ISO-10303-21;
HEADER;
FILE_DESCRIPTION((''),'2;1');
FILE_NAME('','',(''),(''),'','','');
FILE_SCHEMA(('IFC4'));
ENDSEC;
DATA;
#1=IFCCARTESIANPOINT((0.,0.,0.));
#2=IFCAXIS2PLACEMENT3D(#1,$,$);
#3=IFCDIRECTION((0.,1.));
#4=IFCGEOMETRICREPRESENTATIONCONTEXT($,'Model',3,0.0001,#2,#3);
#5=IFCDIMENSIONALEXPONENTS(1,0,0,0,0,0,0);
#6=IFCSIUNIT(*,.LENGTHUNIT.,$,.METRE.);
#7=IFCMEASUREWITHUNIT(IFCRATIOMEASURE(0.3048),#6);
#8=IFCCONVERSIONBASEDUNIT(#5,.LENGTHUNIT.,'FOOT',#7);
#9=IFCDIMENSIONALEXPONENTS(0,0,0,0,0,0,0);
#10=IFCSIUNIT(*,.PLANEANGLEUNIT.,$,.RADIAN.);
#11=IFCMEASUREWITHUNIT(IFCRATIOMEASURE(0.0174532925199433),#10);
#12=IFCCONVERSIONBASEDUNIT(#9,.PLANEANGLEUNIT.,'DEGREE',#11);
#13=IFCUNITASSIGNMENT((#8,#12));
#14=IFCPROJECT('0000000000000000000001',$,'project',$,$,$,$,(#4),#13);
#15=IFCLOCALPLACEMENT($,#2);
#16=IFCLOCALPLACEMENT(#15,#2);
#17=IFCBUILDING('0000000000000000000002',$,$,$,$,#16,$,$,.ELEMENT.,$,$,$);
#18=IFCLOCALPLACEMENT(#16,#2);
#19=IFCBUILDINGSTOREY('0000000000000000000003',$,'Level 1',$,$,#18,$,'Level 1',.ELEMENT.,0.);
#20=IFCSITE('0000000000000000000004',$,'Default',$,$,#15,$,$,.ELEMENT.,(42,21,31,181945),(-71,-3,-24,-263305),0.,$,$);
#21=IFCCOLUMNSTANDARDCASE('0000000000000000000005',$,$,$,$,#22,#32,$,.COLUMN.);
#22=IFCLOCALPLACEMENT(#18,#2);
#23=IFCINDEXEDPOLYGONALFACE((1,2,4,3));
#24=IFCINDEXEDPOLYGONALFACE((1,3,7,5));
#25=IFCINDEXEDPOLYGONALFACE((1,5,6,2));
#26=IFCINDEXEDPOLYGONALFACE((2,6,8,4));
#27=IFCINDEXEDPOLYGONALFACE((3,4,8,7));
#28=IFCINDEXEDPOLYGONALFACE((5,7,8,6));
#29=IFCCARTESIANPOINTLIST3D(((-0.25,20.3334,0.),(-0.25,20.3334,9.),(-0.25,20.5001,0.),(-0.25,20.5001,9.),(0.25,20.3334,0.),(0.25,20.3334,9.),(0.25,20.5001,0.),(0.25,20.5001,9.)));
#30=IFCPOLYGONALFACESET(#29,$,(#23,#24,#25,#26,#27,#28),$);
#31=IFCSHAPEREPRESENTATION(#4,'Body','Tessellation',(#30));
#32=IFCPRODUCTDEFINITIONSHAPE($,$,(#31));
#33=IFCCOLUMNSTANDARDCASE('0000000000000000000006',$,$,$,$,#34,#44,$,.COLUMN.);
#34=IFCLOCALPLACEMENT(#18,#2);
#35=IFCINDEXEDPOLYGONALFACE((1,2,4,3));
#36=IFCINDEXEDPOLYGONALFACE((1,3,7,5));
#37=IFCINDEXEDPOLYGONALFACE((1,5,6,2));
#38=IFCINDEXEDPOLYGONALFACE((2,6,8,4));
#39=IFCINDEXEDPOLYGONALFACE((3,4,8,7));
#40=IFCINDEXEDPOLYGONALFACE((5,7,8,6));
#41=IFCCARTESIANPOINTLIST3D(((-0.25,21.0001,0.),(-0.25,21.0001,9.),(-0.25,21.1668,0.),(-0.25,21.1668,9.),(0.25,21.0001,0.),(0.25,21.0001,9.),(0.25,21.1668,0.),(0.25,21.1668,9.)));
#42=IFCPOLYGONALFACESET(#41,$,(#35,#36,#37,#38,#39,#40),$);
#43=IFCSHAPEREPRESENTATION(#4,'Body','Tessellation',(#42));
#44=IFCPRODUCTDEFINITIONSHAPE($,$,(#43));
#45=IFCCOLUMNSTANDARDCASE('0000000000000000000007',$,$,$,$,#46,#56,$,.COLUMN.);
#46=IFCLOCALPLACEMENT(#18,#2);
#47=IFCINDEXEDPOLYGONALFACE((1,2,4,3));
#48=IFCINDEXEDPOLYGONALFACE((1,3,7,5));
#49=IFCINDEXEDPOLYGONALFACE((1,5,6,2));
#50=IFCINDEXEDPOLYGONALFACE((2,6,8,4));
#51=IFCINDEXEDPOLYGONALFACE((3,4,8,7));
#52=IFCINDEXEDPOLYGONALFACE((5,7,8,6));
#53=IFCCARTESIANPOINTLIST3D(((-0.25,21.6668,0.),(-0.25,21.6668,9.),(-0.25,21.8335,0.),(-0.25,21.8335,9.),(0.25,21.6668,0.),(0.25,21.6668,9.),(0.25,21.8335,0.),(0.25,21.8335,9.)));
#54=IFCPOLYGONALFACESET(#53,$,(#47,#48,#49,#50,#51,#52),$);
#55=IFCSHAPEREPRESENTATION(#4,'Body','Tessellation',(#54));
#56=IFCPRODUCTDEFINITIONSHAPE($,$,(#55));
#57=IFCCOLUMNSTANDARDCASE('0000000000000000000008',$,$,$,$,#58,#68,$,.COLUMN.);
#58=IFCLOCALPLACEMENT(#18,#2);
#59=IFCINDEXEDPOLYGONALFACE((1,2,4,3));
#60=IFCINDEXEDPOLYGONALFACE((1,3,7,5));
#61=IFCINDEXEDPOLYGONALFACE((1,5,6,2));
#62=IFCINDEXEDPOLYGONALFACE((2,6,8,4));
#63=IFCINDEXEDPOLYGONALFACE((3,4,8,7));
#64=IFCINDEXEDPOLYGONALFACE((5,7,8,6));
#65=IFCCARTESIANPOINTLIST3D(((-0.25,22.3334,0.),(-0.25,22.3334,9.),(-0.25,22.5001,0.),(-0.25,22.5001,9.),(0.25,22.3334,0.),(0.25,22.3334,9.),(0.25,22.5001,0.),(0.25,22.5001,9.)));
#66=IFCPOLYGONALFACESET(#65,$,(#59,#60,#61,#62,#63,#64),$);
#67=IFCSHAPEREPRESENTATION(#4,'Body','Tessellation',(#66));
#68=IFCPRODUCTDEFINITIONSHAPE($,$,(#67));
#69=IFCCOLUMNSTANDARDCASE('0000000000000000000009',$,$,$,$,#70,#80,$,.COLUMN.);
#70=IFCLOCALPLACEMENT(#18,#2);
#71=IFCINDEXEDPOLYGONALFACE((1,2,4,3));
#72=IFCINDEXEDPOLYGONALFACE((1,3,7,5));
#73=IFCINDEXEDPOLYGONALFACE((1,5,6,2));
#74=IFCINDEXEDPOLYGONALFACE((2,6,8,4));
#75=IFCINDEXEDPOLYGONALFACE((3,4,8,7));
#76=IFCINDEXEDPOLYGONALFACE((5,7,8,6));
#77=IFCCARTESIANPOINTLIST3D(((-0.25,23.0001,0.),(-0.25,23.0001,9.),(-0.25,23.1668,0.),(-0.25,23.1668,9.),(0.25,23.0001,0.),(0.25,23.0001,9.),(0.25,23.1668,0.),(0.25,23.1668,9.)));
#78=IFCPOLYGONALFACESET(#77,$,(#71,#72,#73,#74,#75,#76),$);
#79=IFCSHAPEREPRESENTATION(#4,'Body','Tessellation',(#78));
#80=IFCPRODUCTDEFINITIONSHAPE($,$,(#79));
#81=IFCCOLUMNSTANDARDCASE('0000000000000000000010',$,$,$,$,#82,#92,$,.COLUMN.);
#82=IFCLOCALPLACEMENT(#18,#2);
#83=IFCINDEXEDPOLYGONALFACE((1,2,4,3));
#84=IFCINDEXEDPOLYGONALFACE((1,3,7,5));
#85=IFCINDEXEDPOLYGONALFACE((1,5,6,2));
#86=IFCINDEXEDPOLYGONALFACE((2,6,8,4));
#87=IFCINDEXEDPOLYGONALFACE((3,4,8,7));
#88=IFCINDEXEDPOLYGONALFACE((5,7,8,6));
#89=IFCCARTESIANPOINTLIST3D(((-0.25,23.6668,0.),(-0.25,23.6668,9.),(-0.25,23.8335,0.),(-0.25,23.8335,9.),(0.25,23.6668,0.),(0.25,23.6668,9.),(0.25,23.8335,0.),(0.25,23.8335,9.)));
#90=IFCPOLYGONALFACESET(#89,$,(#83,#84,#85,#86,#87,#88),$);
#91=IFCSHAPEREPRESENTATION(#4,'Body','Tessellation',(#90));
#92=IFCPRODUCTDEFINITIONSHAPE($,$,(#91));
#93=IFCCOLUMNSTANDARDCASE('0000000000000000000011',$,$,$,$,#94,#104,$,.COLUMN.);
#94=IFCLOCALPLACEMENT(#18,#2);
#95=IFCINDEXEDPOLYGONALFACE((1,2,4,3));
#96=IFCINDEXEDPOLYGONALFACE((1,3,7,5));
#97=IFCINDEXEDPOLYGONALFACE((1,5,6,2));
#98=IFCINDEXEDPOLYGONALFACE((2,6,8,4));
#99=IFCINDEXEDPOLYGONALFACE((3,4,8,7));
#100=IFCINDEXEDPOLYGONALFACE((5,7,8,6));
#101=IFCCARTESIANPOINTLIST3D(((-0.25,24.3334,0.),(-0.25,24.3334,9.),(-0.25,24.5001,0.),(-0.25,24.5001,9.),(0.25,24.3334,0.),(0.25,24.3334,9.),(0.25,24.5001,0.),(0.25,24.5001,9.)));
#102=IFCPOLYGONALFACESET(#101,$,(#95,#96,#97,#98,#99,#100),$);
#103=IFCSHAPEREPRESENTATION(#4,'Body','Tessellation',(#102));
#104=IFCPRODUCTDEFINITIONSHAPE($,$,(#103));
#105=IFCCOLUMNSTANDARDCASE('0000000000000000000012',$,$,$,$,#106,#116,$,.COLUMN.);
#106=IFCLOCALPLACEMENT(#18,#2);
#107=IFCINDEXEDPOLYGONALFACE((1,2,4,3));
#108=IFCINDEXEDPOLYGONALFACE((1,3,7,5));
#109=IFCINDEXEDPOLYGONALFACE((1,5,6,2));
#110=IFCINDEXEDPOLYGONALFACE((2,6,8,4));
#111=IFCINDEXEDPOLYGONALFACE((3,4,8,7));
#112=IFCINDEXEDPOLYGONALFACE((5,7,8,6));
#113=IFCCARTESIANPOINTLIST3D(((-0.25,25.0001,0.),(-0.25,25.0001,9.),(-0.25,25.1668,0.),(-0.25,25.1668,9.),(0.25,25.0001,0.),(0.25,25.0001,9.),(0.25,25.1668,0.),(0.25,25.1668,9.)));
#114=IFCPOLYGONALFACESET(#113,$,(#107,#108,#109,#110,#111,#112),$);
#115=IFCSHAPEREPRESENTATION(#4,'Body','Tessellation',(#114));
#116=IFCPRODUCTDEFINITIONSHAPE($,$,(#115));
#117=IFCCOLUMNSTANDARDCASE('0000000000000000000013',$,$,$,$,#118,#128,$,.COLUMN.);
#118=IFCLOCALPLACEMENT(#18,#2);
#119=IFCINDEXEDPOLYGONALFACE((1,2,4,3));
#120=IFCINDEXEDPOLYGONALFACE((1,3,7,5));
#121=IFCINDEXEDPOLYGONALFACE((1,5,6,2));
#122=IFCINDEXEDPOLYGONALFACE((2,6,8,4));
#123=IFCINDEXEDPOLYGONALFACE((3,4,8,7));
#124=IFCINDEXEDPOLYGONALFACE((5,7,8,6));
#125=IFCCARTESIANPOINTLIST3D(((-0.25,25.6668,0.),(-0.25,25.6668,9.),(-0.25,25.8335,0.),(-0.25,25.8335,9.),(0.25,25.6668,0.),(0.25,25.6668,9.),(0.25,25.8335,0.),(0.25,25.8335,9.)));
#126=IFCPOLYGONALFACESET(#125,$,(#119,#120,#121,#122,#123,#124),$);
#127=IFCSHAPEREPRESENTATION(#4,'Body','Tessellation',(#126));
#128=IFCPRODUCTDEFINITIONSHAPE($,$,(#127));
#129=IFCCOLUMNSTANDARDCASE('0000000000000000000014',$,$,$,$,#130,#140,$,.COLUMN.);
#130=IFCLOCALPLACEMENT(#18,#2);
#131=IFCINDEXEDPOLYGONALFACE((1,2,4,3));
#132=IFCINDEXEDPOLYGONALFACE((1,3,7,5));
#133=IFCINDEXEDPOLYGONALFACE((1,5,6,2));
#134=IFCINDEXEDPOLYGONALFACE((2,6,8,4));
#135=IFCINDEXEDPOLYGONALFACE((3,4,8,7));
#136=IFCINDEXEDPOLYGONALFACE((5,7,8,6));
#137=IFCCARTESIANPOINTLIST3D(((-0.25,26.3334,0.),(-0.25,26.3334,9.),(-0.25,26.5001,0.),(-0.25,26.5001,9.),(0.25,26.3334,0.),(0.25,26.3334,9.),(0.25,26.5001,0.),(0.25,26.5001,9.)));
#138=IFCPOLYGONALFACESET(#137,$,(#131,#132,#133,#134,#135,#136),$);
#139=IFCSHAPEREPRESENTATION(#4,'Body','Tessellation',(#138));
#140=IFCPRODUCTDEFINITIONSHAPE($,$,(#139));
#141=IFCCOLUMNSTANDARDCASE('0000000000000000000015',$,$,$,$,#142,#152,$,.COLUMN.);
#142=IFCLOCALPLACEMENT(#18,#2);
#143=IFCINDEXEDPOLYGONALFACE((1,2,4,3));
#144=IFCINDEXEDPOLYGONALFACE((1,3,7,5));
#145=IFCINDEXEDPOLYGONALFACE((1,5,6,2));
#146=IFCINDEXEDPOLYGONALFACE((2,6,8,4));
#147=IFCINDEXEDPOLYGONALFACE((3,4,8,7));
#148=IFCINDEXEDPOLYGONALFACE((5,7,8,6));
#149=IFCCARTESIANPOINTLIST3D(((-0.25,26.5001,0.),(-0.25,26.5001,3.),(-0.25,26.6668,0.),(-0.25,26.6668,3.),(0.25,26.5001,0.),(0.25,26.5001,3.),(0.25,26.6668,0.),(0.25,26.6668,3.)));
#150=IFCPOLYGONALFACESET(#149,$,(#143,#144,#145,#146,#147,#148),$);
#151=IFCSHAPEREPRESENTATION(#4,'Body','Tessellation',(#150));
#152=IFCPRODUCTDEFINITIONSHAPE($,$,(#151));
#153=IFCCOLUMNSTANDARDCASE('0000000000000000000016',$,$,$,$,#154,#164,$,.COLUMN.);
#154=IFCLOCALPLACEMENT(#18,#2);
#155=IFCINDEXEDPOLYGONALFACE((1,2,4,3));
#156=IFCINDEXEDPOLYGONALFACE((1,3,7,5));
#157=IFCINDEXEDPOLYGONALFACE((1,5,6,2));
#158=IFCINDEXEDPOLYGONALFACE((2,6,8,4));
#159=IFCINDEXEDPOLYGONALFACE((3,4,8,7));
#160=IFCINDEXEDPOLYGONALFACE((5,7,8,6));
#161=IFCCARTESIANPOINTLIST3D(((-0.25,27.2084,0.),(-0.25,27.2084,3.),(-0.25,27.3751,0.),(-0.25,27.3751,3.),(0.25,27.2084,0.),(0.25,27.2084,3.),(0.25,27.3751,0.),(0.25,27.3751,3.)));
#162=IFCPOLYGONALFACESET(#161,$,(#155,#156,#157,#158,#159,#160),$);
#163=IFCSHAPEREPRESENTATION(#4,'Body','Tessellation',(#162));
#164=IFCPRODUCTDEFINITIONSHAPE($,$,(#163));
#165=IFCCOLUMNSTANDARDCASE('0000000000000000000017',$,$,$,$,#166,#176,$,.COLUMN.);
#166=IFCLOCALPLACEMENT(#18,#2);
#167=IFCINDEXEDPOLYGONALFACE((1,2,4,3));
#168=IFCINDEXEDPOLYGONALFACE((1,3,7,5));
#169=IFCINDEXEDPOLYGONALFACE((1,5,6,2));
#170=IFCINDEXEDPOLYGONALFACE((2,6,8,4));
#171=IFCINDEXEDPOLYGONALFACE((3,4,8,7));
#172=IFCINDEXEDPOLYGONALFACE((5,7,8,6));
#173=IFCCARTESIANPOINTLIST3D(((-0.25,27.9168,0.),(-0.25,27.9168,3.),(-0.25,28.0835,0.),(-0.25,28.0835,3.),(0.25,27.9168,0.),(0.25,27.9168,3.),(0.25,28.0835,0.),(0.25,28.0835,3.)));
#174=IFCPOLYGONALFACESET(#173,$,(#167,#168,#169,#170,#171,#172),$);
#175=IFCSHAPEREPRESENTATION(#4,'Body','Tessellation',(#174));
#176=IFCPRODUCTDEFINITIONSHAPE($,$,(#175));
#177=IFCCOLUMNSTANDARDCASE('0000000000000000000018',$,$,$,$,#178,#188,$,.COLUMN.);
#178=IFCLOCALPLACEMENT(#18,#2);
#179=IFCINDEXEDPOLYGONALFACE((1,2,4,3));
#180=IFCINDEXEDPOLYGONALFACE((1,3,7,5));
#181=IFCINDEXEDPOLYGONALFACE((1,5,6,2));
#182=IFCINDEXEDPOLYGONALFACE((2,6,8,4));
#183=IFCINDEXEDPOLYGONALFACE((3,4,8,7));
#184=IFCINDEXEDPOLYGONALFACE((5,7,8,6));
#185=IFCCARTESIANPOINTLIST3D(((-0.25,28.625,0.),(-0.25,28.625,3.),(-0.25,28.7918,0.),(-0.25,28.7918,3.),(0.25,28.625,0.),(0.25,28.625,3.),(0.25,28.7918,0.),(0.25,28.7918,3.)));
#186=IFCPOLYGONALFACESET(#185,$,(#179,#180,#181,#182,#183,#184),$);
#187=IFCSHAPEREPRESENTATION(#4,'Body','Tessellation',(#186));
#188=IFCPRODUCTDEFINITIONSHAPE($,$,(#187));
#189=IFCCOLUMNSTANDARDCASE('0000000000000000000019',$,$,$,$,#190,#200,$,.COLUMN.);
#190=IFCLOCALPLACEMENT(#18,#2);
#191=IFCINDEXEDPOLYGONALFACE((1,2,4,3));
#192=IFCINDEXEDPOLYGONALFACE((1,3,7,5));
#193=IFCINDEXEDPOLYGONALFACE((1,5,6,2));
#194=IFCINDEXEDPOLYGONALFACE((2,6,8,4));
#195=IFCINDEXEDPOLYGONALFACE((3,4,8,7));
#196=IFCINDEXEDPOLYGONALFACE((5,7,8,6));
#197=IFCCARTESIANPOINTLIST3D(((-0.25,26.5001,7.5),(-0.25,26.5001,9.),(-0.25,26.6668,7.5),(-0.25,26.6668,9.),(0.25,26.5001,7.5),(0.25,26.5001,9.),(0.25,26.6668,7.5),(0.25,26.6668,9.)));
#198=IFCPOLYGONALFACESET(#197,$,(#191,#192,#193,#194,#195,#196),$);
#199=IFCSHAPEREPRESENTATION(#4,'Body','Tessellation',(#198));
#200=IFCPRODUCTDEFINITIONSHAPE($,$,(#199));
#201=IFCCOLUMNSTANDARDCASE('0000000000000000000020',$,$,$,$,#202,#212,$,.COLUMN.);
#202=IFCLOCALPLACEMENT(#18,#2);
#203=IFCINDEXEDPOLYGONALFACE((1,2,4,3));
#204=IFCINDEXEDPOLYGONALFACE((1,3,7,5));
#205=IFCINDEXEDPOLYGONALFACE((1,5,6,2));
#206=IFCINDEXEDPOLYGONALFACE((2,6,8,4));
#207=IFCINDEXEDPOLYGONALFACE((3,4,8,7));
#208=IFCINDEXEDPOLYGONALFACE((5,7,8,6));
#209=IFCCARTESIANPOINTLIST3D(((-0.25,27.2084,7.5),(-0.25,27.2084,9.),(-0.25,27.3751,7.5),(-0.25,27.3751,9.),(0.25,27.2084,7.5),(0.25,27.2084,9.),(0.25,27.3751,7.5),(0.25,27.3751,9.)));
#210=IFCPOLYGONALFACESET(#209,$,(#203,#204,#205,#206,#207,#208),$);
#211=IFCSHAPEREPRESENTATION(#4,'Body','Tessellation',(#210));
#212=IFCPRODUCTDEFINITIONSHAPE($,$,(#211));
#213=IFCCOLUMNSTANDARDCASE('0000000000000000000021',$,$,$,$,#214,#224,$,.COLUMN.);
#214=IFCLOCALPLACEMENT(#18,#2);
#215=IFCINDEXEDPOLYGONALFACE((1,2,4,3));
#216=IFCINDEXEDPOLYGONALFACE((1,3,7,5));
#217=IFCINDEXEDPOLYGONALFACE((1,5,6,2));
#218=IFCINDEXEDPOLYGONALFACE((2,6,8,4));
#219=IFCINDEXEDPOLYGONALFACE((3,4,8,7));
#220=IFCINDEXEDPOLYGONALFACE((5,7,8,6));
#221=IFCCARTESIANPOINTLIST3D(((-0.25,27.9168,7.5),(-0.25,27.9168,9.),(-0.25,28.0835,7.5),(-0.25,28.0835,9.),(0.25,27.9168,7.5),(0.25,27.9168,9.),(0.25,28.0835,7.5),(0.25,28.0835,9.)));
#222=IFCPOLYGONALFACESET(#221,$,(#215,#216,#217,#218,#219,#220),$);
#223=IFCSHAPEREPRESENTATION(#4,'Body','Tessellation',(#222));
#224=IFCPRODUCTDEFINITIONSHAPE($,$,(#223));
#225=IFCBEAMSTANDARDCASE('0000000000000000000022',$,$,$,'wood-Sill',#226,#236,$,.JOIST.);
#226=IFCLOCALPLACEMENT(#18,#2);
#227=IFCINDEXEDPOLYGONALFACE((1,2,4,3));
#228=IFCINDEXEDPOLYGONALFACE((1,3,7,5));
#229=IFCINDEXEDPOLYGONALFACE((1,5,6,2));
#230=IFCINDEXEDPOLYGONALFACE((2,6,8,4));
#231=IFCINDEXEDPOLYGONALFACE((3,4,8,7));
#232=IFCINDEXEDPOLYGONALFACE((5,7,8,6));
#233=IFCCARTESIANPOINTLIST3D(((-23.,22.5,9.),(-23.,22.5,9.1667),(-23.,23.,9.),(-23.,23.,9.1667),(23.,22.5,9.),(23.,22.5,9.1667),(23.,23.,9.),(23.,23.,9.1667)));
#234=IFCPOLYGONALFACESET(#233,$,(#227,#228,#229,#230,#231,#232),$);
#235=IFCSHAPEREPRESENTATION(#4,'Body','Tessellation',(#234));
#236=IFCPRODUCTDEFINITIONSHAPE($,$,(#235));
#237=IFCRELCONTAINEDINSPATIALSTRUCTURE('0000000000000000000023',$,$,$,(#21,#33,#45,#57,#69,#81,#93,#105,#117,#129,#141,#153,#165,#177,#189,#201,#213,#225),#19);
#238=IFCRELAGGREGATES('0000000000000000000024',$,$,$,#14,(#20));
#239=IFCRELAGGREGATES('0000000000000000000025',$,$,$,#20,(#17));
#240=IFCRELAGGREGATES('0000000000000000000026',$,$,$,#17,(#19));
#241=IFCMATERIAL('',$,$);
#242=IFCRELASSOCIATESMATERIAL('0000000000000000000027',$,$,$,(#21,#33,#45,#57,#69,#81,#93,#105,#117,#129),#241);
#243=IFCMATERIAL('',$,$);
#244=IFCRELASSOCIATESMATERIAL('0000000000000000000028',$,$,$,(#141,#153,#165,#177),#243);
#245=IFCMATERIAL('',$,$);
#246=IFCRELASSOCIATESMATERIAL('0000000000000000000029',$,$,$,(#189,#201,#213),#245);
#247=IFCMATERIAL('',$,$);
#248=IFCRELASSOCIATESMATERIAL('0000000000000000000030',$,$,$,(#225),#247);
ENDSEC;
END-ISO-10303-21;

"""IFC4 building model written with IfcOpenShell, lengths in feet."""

from ifc_helpers import new_model, entity, si_unit, converted_unit, direction, frame, origin, place, context, project, spatial, rectangle, extrude, material, element, save


model = new_model("IFC4")

# Units and contexts
model_context = context("Model", 3, precision=0.0001, world=origin(), true_north=direction((0.0, 1.0)))
ifc_project = project(units=[converted_unit("LENGTHUNIT", "FOOT", entity("IfcRatioMeasure", 0.3048), si_unit("LENGTHUNIT", "METRE"), dimensions=[1, 0, 0, 0, 0, 0, 0]), converted_unit("PLANEANGLEUNIT", "DEGREE", entity("IfcRatioMeasure", 0.0174532925199433), si_unit("PLANEANGLEUNIT", "RADIAN"), dimensions=[0, 0, 0, 0, 0, 0, 0])], contexts=[model_context])

# Site, building, storey
site_placement = place(None, origin())
site = spatial("IfcSite", under=ifc_project, at=site_placement, Name="Default", CompositionType="ELEMENT", RefLatitude=(42, 21, 31, 181945), RefLongitude=(-71, -3, -24, -263305), RefElevation=0.0)
building_placement = place(site_placement, origin())
building = spatial("IfcBuilding", under=site, at=building_placement, CompositionType="ELEMENT")
storey_placement = place(building_placement, origin())
storey = spatial("IfcBuildingStorey", under=building, at=storey_placement, Name="Level 1", LongName="Level 1", CompositionType="ELEMENT", Elevation=0.0)

# Columns
ifc_material_1 = material(Name="")
placement = place(storey_placement, frame((0.0, -0.25, 0.0), z_axis=(0.0, 0.0, 1.0), x_axis=(0.0, 1.0, 0.0)))
for number, where, z_axis, x_axis in (
    (1, (20.6667, 0.0, 0.0), (0.0, 0.0, 1.0), (1.0, 0.0, 0.0)),
    (2, (21.3334, 0.0, 0.0), (0.0, 0.0, 1.0), (1.0, 0.0, 0.0)),
    (3, (22.0001, 0.0, 0.0), (0.0, 0.0, 1.0), (1.0, 0.0, 0.0)),
    (4, (22.6667, 0.0, 0.0), (0.0, 0.0, 1.0), (1.0, 0.0, 0.0)),
    (5, (23.3334, 0.0, 0.0), (0.0, 0.0, 1.0), (1.0, 0.0, 0.0)),
    (6, (24.0001, 0.0, 0.0), (0.0, 0.0, 1.0), (1.0, 0.0, 0.0)),
    (7, (24.6667, 0.0, 0.0), (0.0, 0.0, 1.0), (1.0, 0.0, 0.0)),
    (8, (25.3334, 0.0, 0.0), (0.0, 0.0, 1.0), (1.0, 0.0, 0.0)),
    (9, (26.0001, 0.0, 0.0), (0.0, 0.0, 1.0), (1.0, 0.0, 0.0)),
    (10, (26.6667, 0.0, 0.0), (0.0, 0.0, 1.0), (1.0, 0.0, 0.0)),
):
    element("IfcColumnStandardCase", number, at=place(placement, frame(where, z_axis=z_axis, x_axis=x_axis)), inside=storey, material=ifc_material_1, PredefinedType="COLUMN", context=model_context, shape_type="SweptSolid", body=[
        extrude(rectangle(XDim=0.1667, YDim=0.5), origin(), (0.0, 0.0, 1.0), 9.0),
    ])
ifc_material_2 = material(Name="")
for number, where, z_axis, x_axis in (
    (11, (26.8334, 0.0, 0.0), (0.0, 0.0, 1.0), (1.0, 0.0, 0.0)),
    (12, (27.5417, 0.0, 0.0), (0.0, 0.0, 1.0), (1.0, 0.0, 0.0)),
    (13, (28.2501, 0.0, 0.0), (0.0, 0.0, 1.0), (1.0, 0.0, 0.0)),
    (14, (28.9584, 0.0, 0.0), (0.0, 0.0, 1.0), (1.0, 0.0, 0.0)),
):
    element("IfcColumnStandardCase", number, at=place(placement, frame(where, z_axis=z_axis, x_axis=x_axis)), inside=storey, material=ifc_material_2, PredefinedType="COLUMN", context=model_context, shape_type="SweptSolid", body=[
        extrude(rectangle(XDim=0.1667, YDim=0.5), origin(), (0.0, 0.0, 1.0), 3.0),
    ])
ifc_material_3 = material(Name="")
for number, where, z_axis, x_axis in (
    (15, (26.8334, 0.0, 7.5), (0.0, 0.0, 1.0), (1.0, 0.0, 0.0)),
    (16, (27.5417, 0.0, 7.5), (0.0, 0.0, 1.0), (1.0, 0.0, 0.0)),
    (17, (28.2501, 0.0, 7.5), (0.0, 0.0, 1.0), (1.0, 0.0, 0.0)),
):
    element("IfcColumnStandardCase", number, at=place(placement, frame(where, z_axis=z_axis, x_axis=x_axis)), inside=storey, material=ifc_material_3, PredefinedType="COLUMN", context=model_context, shape_type="SweptSolid", body=[
        extrude(rectangle(XDim=0.1667, YDim=0.5), origin(), (0.0, 0.0, 1.0), 1.5),
    ])

# Beam
ifc_material_4 = material(Name="")
beam_1_placement = place(placement, frame((23.0, 0.0, 9.0), z_axis=(0.0, 0.0, 1.0), x_axis=(0.0, 1.0, 0.0)))
element("IfcBeamStandardCase", 18, at=beam_1_placement, inside=storey, material=ifc_material_4, ObjectType="wood-Sill", PredefinedType="JOIST", context=model_context, shape_type="SweptSolid", body=[
    extrude(rectangle(XDim=46.0, YDim=0.5), origin(), (0.0, 0.0, 1.0), 0.1667),
])

save(model, "model.ifc")
